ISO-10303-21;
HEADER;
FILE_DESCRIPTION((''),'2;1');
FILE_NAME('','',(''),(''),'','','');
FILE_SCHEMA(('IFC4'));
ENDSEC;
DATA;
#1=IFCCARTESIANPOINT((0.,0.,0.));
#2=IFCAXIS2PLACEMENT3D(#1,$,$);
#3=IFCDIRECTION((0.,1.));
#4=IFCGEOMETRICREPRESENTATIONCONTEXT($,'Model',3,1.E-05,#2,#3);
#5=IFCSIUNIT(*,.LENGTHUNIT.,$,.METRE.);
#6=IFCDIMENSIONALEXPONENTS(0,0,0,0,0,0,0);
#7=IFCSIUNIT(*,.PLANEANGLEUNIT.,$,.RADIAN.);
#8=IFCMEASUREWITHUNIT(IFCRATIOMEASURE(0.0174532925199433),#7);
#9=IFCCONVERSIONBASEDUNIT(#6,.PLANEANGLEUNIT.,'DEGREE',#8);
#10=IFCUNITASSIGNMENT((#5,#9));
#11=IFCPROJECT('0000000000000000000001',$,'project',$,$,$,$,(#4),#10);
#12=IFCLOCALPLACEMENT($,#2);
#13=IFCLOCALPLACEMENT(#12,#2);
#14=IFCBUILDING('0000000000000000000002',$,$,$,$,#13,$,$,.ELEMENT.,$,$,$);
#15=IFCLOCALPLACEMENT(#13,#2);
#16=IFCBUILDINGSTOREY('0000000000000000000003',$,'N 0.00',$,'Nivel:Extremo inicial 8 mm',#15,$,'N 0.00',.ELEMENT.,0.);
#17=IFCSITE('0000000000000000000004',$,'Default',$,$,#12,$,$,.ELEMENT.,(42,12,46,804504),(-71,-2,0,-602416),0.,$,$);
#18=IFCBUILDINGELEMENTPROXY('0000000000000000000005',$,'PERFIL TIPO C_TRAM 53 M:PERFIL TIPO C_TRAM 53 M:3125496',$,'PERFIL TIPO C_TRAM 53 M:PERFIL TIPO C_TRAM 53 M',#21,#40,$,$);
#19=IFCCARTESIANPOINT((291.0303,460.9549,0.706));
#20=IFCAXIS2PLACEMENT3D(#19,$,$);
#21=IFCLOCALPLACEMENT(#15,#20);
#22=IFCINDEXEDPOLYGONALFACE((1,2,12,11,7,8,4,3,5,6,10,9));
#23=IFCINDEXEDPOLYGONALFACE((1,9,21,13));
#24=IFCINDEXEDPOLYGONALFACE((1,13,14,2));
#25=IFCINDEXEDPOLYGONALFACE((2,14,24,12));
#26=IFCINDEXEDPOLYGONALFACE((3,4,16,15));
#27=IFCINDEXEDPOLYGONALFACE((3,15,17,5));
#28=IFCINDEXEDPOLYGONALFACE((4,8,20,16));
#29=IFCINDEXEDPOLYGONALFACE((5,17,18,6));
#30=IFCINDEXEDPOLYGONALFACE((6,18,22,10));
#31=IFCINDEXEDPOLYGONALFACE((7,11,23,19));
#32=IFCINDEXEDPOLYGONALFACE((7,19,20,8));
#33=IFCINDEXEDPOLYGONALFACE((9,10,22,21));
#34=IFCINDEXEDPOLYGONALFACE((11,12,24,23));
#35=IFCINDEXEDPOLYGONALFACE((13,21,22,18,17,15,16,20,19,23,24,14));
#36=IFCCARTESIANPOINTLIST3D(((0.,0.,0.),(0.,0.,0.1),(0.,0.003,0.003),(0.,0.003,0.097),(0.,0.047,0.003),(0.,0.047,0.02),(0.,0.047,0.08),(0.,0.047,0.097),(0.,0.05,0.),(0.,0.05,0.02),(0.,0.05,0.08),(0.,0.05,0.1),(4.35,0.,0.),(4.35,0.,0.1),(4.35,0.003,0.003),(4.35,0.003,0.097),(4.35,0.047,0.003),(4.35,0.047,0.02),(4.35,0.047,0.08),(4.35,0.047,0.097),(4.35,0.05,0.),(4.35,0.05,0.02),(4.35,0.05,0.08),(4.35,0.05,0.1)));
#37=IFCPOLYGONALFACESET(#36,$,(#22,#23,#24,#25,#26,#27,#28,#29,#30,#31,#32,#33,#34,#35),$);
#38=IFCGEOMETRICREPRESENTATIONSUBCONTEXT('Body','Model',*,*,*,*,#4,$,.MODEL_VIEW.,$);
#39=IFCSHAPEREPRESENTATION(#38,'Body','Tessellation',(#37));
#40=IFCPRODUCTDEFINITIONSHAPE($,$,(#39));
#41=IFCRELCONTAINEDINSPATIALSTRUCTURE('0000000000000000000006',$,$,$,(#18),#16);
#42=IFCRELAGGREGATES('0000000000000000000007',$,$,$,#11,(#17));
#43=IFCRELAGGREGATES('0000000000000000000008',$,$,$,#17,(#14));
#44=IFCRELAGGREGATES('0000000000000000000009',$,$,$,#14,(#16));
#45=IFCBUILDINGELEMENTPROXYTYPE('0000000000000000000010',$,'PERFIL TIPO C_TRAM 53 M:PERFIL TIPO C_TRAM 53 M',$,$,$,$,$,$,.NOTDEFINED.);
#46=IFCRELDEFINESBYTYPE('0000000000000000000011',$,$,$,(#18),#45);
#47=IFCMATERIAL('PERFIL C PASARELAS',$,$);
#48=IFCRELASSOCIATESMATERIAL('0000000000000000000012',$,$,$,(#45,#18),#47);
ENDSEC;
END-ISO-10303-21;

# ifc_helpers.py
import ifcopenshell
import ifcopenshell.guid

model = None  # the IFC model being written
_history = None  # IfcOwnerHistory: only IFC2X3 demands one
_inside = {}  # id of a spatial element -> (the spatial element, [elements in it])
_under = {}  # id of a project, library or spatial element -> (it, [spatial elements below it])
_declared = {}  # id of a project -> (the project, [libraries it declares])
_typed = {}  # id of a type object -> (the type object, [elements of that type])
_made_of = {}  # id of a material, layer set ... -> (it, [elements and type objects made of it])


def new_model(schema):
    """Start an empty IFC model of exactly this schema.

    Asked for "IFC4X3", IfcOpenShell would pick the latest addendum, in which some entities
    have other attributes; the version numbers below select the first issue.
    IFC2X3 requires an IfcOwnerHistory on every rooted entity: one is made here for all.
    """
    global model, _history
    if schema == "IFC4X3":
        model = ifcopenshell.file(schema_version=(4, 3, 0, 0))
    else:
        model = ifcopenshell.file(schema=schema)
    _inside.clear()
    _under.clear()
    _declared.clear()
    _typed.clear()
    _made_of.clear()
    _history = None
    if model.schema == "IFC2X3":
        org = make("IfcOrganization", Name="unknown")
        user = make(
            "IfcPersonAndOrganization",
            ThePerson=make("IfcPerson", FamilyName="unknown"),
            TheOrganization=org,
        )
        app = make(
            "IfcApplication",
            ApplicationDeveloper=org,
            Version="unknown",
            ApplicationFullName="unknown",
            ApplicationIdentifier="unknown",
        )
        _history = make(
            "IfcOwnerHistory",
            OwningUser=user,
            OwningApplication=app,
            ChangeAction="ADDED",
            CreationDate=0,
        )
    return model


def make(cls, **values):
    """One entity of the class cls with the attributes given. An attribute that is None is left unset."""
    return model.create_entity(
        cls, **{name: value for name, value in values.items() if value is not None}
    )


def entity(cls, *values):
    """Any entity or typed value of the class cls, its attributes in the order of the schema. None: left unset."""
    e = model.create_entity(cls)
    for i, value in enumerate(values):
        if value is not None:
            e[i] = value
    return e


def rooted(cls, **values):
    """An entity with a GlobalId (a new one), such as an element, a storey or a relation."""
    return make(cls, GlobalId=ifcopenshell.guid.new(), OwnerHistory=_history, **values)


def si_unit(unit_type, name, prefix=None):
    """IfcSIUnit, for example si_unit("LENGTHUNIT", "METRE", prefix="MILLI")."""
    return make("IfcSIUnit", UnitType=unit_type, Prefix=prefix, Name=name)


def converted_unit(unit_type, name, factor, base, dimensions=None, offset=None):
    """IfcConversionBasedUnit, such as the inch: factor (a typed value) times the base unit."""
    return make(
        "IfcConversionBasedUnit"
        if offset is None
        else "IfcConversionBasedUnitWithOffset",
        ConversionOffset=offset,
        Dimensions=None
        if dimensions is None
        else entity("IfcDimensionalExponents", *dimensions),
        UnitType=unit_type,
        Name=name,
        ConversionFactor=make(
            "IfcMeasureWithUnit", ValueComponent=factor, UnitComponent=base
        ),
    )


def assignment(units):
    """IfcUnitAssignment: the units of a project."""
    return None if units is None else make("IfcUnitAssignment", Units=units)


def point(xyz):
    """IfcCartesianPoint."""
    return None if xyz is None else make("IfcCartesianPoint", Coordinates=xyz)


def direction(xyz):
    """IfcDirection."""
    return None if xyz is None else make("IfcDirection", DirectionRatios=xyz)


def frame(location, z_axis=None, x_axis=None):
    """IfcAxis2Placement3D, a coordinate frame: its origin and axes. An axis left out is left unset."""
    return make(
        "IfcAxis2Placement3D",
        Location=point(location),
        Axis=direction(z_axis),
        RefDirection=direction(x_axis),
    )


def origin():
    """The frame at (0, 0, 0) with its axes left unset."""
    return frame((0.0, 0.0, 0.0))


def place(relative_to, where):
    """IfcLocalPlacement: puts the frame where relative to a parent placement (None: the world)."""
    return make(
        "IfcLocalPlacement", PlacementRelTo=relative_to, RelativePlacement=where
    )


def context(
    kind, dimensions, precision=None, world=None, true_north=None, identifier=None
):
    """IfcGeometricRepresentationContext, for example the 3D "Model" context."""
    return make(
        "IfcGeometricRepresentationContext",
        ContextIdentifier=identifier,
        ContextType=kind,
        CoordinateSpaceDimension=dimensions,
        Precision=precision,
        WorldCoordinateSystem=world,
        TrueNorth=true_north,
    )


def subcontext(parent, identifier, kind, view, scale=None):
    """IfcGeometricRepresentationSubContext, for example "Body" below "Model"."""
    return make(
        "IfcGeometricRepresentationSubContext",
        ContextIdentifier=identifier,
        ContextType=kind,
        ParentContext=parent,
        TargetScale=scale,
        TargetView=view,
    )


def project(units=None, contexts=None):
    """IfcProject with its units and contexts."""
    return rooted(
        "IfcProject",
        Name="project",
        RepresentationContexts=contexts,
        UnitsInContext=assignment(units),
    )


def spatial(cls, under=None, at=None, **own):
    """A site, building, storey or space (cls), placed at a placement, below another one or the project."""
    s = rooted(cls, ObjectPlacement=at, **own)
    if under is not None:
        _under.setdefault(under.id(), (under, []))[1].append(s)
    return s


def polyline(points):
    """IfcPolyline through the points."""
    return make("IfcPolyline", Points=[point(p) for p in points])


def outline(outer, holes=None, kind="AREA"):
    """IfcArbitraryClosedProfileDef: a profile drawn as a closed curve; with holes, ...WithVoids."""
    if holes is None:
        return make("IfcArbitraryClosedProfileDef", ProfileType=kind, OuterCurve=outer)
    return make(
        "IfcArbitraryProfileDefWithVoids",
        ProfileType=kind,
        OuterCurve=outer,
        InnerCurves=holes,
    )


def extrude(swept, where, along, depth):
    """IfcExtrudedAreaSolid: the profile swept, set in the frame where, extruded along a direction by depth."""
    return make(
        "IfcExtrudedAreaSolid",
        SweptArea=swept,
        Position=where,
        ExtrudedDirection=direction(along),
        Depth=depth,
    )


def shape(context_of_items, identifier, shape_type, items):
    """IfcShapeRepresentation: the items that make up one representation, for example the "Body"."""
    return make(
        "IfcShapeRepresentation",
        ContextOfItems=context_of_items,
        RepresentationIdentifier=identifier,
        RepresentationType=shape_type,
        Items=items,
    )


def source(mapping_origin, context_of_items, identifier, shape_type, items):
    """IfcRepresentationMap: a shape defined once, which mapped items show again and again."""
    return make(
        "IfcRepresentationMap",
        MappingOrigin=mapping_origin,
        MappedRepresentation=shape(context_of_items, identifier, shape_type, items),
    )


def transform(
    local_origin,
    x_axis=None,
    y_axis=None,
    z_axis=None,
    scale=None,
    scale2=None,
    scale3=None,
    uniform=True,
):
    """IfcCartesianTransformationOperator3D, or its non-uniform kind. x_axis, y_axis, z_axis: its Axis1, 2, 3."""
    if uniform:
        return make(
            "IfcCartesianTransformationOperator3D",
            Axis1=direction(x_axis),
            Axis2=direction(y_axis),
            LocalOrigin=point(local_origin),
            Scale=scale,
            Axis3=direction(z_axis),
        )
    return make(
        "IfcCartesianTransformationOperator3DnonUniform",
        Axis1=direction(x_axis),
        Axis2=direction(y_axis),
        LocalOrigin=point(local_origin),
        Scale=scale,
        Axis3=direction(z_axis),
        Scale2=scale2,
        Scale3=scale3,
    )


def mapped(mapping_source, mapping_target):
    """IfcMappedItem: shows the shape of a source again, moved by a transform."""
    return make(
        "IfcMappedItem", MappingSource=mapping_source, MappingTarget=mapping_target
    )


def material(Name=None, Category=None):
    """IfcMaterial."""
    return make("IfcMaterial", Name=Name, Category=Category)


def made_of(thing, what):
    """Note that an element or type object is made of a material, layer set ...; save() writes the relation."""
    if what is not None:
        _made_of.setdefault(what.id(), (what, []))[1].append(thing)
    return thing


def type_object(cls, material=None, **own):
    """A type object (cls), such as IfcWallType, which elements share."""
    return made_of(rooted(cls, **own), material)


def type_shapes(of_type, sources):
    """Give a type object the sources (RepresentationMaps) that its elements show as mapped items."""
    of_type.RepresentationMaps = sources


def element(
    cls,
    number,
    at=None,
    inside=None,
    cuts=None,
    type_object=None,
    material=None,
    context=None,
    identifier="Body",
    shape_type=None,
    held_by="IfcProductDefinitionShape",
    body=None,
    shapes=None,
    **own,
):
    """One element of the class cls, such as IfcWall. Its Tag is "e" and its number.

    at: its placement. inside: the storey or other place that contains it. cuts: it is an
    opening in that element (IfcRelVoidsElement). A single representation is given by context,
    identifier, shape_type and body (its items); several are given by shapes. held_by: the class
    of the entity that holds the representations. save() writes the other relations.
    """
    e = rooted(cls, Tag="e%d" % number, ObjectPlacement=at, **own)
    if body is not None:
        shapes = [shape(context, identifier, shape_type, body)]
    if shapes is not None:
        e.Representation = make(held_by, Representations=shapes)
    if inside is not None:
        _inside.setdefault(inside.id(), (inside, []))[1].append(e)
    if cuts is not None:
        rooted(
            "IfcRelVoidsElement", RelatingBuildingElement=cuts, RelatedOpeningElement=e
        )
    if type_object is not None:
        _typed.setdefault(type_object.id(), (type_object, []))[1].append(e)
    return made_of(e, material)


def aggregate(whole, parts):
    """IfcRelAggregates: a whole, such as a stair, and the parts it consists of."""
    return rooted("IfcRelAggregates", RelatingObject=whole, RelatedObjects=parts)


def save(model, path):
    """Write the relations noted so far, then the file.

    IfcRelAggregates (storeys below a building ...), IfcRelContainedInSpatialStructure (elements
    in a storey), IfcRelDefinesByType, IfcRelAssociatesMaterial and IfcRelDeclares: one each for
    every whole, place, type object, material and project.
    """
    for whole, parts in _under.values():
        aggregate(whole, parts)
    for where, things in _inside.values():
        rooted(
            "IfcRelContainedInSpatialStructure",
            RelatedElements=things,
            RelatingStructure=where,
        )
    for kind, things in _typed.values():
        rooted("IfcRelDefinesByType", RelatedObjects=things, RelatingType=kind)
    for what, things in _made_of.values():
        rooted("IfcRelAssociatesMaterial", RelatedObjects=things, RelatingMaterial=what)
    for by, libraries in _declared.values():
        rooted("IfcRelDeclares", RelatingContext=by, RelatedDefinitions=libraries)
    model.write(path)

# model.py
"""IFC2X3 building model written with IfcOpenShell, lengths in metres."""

from ifc_helpers import new_model, entity, si_unit, converted_unit, direction, frame, origin, place, context, subcontext, project, spatial, polyline, outline, extrude, source, transform, mapped, material, type_object, type_shapes, element, save


model = new_model("IFC2X3")

# Units and contexts
model_context = context("Model", 3, precision=1e-05, world=origin(), true_north=direction((0.0, 1.0)))
body_context = subcontext(model_context, "Body", "Model", "MODEL_VIEW")
ifc_project = project(units=[si_unit("LENGTHUNIT", "METRE"), converted_unit("PLANEANGLEUNIT", "DEGREE", entity("IfcRatioMeasure", 0.0174532925199433), si_unit("PLANEANGLEUNIT", "RADIAN"), dimensions=[0, 0, 0, 0, 0, 0, 0])], contexts=[model_context])

# Site, building, storey
site_placement = place(None, origin())
site = spatial("IfcSite", under=ifc_project, at=site_placement, Name="Default", CompositionType="ELEMENT", RefLatitude=(42, 12, 46, 804504), RefLongitude=(-71, -2, 0, -602416), RefElevation=0.0)
building_placement = place(site_placement, origin())
building = spatial("IfcBuilding", under=site, at=building_placement, CompositionType="ELEMENT")
storey_placement = place(building_placement, origin())
storey = spatial("IfcBuildingStorey", under=building, at=storey_placement, Name="N 0.00", ObjectType="Nivel:Extremo inicial 8 mm", LongName="N 0.00", CompositionType="ELEMENT", Elevation=0.0)

# Building element proxy
ifc_material_1 = material(Name="PERFIL C PASARELAS")
building_element_proxy_type_1 = type_object("IfcBuildingElementProxyType", Name="PERFIL TIPO C_TRAM 53 M:PERFIL TIPO C_TRAM 53 M", PredefinedType="NOTDEFINED", material=ifc_material_1)
shared_shape_1 = source(origin(), body_context, "Body", "SweptSolid", [
    extrude(outline(polyline([(-0.0172, 0.03), (-0.0142, 0.03), (-0.0142, 0.047), (0.0298, 0.047), (0.0298, -0.047), (-0.0142, -0.047), (-0.0142, -0.03), (-0.0172, -0.03), (-0.0172, -0.05), (0.0328, -0.05), (0.0328, 0.05), (-0.0172, 0.05), (-0.0172, 0.03)])), frame((0.0, 0.0328, 0.05), z_axis=(1.0, 0.0, 0.0), x_axis=(0.0, -1.0, 0.0)), (0.0, 0.0, 1.0), 4.35),
])
type_shapes(building_element_proxy_type_1, [shared_shape_1])
proxy_1_placement = place(storey_placement, frame((291.0303, 460.9549, 0.706)))
element("IfcBuildingElementProxy", 1, at=proxy_1_placement, inside=storey, type_object=building_element_proxy_type_1, material=ifc_material_1, Name="PERFIL TIPO C_TRAM 53 M:PERFIL TIPO C_TRAM 53 M:3125496", ObjectType="PERFIL TIPO C_TRAM 53 M:PERFIL TIPO C_TRAM 53 M", context=body_context, shape_type="MappedRepresentation", body=[
    mapped(shared_shape_1, transform((0.0, 0.0, 0.0), scale=1.0)),
])

save(model, "model.ifc")
